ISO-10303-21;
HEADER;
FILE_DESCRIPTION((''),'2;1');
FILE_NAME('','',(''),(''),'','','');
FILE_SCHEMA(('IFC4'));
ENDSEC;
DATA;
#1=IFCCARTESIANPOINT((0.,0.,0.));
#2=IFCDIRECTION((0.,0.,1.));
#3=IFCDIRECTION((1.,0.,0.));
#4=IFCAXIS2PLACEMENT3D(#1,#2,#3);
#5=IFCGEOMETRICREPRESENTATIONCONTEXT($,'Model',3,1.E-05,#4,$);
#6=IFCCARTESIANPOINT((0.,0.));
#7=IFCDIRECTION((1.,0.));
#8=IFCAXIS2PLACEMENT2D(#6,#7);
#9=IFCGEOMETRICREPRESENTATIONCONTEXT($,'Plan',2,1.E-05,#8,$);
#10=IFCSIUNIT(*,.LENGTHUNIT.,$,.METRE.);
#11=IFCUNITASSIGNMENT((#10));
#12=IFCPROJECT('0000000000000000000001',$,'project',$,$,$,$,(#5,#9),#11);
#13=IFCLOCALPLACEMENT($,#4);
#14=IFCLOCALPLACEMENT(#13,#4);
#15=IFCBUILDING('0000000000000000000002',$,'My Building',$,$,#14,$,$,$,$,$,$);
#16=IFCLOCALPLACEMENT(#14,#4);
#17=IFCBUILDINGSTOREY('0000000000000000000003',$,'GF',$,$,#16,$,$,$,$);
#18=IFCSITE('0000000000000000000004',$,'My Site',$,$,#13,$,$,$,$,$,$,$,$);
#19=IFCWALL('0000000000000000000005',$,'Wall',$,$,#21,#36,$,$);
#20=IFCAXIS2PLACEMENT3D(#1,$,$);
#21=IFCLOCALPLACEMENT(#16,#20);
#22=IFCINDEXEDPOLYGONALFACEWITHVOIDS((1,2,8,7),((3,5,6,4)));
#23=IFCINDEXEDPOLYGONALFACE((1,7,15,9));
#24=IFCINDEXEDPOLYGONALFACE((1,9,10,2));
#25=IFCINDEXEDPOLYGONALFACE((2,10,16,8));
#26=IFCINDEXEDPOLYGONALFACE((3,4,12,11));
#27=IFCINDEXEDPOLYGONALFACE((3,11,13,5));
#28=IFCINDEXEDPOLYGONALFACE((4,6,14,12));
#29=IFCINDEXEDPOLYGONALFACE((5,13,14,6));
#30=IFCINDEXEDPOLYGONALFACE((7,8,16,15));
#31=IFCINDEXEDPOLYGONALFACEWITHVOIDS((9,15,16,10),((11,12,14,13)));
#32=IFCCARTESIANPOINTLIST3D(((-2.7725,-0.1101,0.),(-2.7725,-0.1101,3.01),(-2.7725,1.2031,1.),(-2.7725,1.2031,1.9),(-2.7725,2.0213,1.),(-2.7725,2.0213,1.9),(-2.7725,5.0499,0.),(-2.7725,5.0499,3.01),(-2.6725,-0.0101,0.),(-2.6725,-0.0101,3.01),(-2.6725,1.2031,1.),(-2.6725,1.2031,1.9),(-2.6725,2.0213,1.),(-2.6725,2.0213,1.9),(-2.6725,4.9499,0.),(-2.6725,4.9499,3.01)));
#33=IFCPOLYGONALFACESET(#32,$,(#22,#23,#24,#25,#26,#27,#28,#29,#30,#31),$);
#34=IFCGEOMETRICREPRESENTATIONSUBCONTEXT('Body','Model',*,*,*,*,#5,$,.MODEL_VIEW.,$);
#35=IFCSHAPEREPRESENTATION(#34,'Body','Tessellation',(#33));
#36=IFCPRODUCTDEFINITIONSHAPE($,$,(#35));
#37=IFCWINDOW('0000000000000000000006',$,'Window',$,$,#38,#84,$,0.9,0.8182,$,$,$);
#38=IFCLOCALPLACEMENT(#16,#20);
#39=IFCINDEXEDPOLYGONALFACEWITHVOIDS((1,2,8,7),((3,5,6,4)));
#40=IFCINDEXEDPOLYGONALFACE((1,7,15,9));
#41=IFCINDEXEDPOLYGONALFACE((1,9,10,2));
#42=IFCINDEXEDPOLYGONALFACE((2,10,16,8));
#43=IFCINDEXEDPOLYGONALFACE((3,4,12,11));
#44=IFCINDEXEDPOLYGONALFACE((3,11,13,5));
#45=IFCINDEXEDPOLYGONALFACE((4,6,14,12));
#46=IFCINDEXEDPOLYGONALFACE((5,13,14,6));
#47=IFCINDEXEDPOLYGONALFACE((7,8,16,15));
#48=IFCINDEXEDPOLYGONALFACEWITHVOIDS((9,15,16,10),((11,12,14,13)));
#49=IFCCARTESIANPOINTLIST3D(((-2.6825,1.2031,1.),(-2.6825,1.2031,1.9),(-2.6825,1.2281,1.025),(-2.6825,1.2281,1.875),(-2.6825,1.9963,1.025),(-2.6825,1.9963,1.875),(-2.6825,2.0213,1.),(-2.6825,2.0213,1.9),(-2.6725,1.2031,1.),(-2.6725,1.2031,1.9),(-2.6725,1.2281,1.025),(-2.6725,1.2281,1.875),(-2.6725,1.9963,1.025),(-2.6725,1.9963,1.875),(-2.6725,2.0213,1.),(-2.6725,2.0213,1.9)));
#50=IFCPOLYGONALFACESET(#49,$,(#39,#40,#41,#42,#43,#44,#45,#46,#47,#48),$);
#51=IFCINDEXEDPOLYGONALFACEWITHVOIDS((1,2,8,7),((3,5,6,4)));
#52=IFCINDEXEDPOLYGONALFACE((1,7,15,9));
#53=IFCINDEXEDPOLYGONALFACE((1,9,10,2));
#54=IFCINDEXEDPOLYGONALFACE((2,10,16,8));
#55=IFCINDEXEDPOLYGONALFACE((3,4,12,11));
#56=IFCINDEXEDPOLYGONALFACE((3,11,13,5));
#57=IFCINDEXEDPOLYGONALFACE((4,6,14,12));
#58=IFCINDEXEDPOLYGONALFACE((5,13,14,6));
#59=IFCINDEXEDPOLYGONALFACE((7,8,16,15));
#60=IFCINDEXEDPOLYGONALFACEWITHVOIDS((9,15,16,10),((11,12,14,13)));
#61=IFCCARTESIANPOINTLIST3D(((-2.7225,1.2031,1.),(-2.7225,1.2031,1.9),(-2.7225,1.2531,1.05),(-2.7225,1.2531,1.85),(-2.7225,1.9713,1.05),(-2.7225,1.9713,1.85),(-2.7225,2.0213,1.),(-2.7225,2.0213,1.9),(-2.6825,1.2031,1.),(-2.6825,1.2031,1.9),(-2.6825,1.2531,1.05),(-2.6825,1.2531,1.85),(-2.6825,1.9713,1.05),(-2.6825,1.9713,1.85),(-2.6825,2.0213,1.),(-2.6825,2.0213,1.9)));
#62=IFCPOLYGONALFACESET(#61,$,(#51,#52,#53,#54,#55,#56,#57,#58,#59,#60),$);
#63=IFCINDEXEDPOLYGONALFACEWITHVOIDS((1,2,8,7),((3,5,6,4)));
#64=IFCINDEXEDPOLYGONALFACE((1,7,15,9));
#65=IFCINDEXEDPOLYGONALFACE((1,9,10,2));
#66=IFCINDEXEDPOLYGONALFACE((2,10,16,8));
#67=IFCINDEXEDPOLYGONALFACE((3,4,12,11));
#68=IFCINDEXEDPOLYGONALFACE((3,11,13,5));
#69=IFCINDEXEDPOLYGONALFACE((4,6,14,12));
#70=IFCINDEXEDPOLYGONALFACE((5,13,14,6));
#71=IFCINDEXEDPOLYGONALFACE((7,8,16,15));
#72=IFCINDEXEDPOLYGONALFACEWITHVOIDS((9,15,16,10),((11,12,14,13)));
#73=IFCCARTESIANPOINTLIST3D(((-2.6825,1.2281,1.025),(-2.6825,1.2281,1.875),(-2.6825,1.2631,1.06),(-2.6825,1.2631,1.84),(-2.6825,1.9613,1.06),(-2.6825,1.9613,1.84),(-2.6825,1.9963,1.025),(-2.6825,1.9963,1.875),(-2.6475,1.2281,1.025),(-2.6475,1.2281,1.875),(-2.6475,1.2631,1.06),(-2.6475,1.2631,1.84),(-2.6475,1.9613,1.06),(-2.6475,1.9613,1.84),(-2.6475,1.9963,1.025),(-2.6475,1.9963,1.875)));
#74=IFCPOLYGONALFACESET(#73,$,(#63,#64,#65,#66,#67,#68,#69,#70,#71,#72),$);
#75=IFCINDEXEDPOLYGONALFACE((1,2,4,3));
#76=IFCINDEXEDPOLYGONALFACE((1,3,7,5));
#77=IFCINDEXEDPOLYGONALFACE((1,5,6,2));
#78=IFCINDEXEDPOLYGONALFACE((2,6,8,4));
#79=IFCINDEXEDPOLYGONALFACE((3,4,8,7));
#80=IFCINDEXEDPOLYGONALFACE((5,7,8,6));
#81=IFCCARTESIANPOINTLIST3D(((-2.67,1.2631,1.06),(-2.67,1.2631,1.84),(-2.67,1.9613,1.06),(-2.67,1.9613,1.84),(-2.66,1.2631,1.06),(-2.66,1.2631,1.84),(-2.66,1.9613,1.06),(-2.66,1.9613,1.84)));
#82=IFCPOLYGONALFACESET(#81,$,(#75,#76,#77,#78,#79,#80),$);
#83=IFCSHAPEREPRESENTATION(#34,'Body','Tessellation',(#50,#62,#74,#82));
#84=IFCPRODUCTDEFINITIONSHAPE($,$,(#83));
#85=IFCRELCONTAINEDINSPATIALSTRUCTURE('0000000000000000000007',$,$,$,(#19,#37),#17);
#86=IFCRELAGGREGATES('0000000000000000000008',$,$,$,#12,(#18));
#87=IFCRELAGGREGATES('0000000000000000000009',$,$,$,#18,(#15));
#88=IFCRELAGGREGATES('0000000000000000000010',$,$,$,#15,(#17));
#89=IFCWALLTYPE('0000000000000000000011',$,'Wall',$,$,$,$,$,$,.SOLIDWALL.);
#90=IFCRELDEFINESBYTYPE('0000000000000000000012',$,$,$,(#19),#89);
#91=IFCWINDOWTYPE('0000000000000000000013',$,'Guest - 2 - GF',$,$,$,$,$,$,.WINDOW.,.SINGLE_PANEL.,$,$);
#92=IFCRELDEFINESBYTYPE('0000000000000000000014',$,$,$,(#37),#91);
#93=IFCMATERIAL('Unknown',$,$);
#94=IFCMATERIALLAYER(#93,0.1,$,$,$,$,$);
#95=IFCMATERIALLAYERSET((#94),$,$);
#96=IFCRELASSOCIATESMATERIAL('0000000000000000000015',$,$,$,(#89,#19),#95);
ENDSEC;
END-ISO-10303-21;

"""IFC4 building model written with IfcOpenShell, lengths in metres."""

from ifc_helpers import new_model, entity, si_unit, frame, origin_with_axes, origin_2d_with_axis, place, context, subcontext, project, spatial, line, indexed_curve, outline, extrude, shape, source, transform, mapped, material, layer, layer_set, layer_usage, type_object, type_shapes, element, fill, save


model = new_model("IFC4")

# Units and contexts
model_context = context("Model", 3, precision=1e-05, world=origin_with_axes())
plan_context = context("Plan", 2, precision=1e-05, world=origin_2d_with_axis())
body_context_1 = subcontext(model_context, "Body", "Model", "MODEL_VIEW")
body_context_2 = subcontext(plan_context, "Body", "Plan", "PLAN_VIEW")
ifc_project = project(units=[si_unit("LENGTHUNIT", "METRE")], contexts=[model_context, plan_context])

# Site, building, storey
site_placement = place(None, origin_with_axes())
site = spatial("IfcSite", under=ifc_project, at=site_placement, Name="My Site")
building_placement = place(site_placement, origin_with_axes())
building = spatial("IfcBuilding", under=site, at=building_placement, Name="My Building")
storey_placement = place(building_placement, origin_with_axes())
storey = spatial("IfcBuildingStorey", under=building, at=storey_placement, Name="GF")

# Shared definitions
ifc_material_1 = material(Name="Unknown")

# Shared definitions
ifc_layer_1 = layer(ifc_material_1, 0.1)
ifc_layer_set_1 = layer_set([ifc_layer_1])
wall_type = type_object("IfcWallType", Name="Wall", PredefinedType="SOLIDWALL", material=ifc_layer_set_1)

# Wall, opening, window
ifc_layer_usage_1 = layer_usage(ifc_layer_set_1, "AXIS2", "POSITIVE", 0.0)
wall_1_placement = place(storey_placement, frame((-2.7725, 5.0499, 0.0), z_axis=(0.0, 0.0, 1.0), x_axis=(0.0, -1.0, 0.0)))
wall_1 = element("IfcWall", 1, at=wall_1_placement, inside=storey, type_object=wall_type, material=ifc_layer_usage_1, Name="Wall", context=body_context_1, shape_type="SweptSolid", body=[
    extrude(outline(indexed_curve([(0.0, 0.0), (0.1, 0.1), (5.06, 0.1), (5.16, 0.0)], segments=[line(1, 2, 3, 4, 1)])), origin_with_axes(), (0.0, 0.0, 1.0), 3.01),
])
shared_shape_1 = source(origin_with_axes(), body_context_1, "Body", "SweptSolid", [
    extrude(outline(indexed_curve([(0.0, 0.0), (0.8182, 0.0), (0.8182, 0.9), (0.0, 0.9)], segments=[line(1, 2, 3, 4, 1)])), frame((0.0, -0.6, 0.0), z_axis=(0.0, -1.0, 0.0), x_axis=(1.0, 0.0, 0.0)), (0.0, 0.0, -1.0), 1.2),
])
opening_1_placement = place(wall_1_placement, frame((3.0286, 0.0, 1.0), z_axis=(0.0, 0.0, 1.0), x_axis=(1.0, 0.0, 0.0)))
opening_1 = element("IfcOpeningElement", 2, at=opening_1_placement, cuts=wall_1, PredefinedType="OPENING", context=body_context_1, shape_type="MappedRepresentation", body=[
    mapped(shared_shape_1, transform((0.0, 0.0, 0.0), x_axis=(1.0, 0.0, 0.0), y_axis=(0.0, 1.0, 0.0), z_axis=(0.0, 0.0, 1.0), scale=1.0)),
])
window_type_1 = type_object("IfcWindowType", Name="Guest - 2 - GF", PartitioningType="SINGLE_PANEL", PredefinedType="WINDOW")
shared_shape_2 = source(origin_with_axes(), body_context_1, "Body", "SweptSolid", [
    extrude(outline(indexed_curve([(0.0, 0.0), (0.8182, 0.0), (0.8182, 0.9), (0.0, 0.9)], segments=[line(1, 2, 3, 4, 1)]), holes=[indexed_curve([(0.025, 0.025), (0.7932, 0.025), (0.7932, 0.875), (0.025, 0.875)], segments=[line(1, 2, 3, 4, 1)])]), frame((0.0, 0.09, 0.0), z_axis=(0.0, -1.0, 0.0), x_axis=(1.0, 0.0, 0.0)), (0.0, 0.0, -1.0), 0.01),
    extrude(outline(indexed_curve([(0.0, 0.0), (0.8182, 0.0), (0.8182, 0.9), (0.0, 0.9)], segments=[line(1, 2, 3, 4, 1)]), holes=[indexed_curve([(0.05, 0.05), (0.7682, 0.05), (0.7682, 0.85), (0.05, 0.85)], segments=[line(1, 2, 3, 4, 1)])]), frame((0.0, 0.05, 0.0), z_axis=(0.0, -1.0, 0.0), x_axis=(1.0, 0.0, 0.0)), (0.0, 0.0, -1.0), 0.04),
    extrude(outline(indexed_curve([(0.0, 0.0), (0.7682, 0.0), (0.7682, 0.85), (0.0, 0.85)], segments=[line(1, 2, 3, 4, 1)]), holes=[indexed_curve([(0.035, 0.035), (0.7332, 0.035), (0.7332, 0.815), (0.035, 0.815)], segments=[line(1, 2, 3, 4, 1)])]), frame((0.025, 0.09, 0.025), z_axis=(0.0, -1.0, 0.0), x_axis=(1.0, 0.0, 0.0)), (0.0, 0.0, -1.0), 0.035),
    extrude(outline(indexed_curve([(0.035, 0.035), (0.7332, 0.035), (0.7332, 0.815), (0.035, 0.815)], segments=[line(1, 2, 3, 4, 1)])), frame((0.025, 0.1025, 0.025), z_axis=(0.0, -1.0, 0.0), x_axis=(1.0, 0.0, 0.0)), (0.0, 0.0, -1.0), 0.01),
])
shared_shape_3 = source(origin_with_axes(), body_context_2, "Body", "Curve2D", [
    entity("IfcIndexedPolyCurve", entity("IfcCartesianPointList2D", [[0.05, 0.05], [0.7682, 0.05]])),
    entity("IfcIndexedPolyCurve", entity("IfcCartesianPointList2D", [[0.0, 0.1], [0.025, 0.1], [0.025, 0.09], [0.05, 0.09], [0.05, 0.05], [0.0, 0.05]]), [entity("IfcLineIndex", [1, 2, 3, 4, 5, 6, 1])]),
    entity("IfcIndexedPolyCurve", entity("IfcCartesianPointList2D", [[0.8182, 0.1], [0.7932, 0.1], [0.7932, 0.09], [0.7682, 0.09], [0.7682, 0.05], [0.8182, 0.05]]), [entity("IfcLineIndex", [1, 2, 3, 4, 5, 6, 1])]),
    entity("IfcIndexedPolyCurve", entity("IfcCartesianPointList2D", [[0.025, 0.09], [0.06, 0.09], [0.06, 0.125], [0.025, 0.125]]), [entity("IfcLineIndex", [1, 2, 3, 4, 1])]),
    entity("IfcIndexedPolyCurve", entity("IfcCartesianPointList2D", [[0.7932, 0.09], [0.7582, 0.09], [0.7582, 0.125], [0.7932, 0.125]]), [entity("IfcLineIndex", [1, 2, 3, 4, 1])]),
    entity("IfcIndexedPolyCurve", entity("IfcCartesianPointList2D", [[0.06, 0.09], [0.7582, 0.09]])),
    entity("IfcIndexedPolyCurve", entity("IfcCartesianPointList2D", [[0.06, 0.125], [0.7582, 0.125]])),
    entity("IfcIndexedPolyCurve", entity("IfcCartesianPointList2D", [[0.06, 0.1075], [0.7582, 0.1075]])),
])
type_shapes(window_type_1, [shared_shape_2, shared_shape_3])
window_1_placement = place(opening_1_placement, frame((0.0, 0.0, 0.0), z_axis=(0.0, 0.0, 1.0), x_axis=(1.0, 0.0, 0.0)))
window_1 = element("IfcWindow", 3, at=window_1_placement, inside=storey, type_object=window_type_1, Name="Window", OverallHeight=0.9, OverallWidth=0.8182, shapes=[
    shape(body_context_1, "Body", "MappedRepresentation", [mapped(shared_shape_2, transform((0.0, 0.0, 0.0), x_axis=(1.0, 0.0, 0.0), y_axis=(0.0, 1.0, 0.0), z_axis=(0.0, 0.0, 1.0), scale=1.0))]),
    shape(body_context_2, "Body", "MappedRepresentation", [mapped(shared_shape_3, transform((0.0, 0.0, 0.0), x_axis=(1.0, 0.0, 0.0), y_axis=(0.0, 1.0, 0.0), z_axis=(0.0, 0.0, 1.0), scale=1.0))]),
])
fill(opening_1, window_1)

save(model, "model.ifc")
